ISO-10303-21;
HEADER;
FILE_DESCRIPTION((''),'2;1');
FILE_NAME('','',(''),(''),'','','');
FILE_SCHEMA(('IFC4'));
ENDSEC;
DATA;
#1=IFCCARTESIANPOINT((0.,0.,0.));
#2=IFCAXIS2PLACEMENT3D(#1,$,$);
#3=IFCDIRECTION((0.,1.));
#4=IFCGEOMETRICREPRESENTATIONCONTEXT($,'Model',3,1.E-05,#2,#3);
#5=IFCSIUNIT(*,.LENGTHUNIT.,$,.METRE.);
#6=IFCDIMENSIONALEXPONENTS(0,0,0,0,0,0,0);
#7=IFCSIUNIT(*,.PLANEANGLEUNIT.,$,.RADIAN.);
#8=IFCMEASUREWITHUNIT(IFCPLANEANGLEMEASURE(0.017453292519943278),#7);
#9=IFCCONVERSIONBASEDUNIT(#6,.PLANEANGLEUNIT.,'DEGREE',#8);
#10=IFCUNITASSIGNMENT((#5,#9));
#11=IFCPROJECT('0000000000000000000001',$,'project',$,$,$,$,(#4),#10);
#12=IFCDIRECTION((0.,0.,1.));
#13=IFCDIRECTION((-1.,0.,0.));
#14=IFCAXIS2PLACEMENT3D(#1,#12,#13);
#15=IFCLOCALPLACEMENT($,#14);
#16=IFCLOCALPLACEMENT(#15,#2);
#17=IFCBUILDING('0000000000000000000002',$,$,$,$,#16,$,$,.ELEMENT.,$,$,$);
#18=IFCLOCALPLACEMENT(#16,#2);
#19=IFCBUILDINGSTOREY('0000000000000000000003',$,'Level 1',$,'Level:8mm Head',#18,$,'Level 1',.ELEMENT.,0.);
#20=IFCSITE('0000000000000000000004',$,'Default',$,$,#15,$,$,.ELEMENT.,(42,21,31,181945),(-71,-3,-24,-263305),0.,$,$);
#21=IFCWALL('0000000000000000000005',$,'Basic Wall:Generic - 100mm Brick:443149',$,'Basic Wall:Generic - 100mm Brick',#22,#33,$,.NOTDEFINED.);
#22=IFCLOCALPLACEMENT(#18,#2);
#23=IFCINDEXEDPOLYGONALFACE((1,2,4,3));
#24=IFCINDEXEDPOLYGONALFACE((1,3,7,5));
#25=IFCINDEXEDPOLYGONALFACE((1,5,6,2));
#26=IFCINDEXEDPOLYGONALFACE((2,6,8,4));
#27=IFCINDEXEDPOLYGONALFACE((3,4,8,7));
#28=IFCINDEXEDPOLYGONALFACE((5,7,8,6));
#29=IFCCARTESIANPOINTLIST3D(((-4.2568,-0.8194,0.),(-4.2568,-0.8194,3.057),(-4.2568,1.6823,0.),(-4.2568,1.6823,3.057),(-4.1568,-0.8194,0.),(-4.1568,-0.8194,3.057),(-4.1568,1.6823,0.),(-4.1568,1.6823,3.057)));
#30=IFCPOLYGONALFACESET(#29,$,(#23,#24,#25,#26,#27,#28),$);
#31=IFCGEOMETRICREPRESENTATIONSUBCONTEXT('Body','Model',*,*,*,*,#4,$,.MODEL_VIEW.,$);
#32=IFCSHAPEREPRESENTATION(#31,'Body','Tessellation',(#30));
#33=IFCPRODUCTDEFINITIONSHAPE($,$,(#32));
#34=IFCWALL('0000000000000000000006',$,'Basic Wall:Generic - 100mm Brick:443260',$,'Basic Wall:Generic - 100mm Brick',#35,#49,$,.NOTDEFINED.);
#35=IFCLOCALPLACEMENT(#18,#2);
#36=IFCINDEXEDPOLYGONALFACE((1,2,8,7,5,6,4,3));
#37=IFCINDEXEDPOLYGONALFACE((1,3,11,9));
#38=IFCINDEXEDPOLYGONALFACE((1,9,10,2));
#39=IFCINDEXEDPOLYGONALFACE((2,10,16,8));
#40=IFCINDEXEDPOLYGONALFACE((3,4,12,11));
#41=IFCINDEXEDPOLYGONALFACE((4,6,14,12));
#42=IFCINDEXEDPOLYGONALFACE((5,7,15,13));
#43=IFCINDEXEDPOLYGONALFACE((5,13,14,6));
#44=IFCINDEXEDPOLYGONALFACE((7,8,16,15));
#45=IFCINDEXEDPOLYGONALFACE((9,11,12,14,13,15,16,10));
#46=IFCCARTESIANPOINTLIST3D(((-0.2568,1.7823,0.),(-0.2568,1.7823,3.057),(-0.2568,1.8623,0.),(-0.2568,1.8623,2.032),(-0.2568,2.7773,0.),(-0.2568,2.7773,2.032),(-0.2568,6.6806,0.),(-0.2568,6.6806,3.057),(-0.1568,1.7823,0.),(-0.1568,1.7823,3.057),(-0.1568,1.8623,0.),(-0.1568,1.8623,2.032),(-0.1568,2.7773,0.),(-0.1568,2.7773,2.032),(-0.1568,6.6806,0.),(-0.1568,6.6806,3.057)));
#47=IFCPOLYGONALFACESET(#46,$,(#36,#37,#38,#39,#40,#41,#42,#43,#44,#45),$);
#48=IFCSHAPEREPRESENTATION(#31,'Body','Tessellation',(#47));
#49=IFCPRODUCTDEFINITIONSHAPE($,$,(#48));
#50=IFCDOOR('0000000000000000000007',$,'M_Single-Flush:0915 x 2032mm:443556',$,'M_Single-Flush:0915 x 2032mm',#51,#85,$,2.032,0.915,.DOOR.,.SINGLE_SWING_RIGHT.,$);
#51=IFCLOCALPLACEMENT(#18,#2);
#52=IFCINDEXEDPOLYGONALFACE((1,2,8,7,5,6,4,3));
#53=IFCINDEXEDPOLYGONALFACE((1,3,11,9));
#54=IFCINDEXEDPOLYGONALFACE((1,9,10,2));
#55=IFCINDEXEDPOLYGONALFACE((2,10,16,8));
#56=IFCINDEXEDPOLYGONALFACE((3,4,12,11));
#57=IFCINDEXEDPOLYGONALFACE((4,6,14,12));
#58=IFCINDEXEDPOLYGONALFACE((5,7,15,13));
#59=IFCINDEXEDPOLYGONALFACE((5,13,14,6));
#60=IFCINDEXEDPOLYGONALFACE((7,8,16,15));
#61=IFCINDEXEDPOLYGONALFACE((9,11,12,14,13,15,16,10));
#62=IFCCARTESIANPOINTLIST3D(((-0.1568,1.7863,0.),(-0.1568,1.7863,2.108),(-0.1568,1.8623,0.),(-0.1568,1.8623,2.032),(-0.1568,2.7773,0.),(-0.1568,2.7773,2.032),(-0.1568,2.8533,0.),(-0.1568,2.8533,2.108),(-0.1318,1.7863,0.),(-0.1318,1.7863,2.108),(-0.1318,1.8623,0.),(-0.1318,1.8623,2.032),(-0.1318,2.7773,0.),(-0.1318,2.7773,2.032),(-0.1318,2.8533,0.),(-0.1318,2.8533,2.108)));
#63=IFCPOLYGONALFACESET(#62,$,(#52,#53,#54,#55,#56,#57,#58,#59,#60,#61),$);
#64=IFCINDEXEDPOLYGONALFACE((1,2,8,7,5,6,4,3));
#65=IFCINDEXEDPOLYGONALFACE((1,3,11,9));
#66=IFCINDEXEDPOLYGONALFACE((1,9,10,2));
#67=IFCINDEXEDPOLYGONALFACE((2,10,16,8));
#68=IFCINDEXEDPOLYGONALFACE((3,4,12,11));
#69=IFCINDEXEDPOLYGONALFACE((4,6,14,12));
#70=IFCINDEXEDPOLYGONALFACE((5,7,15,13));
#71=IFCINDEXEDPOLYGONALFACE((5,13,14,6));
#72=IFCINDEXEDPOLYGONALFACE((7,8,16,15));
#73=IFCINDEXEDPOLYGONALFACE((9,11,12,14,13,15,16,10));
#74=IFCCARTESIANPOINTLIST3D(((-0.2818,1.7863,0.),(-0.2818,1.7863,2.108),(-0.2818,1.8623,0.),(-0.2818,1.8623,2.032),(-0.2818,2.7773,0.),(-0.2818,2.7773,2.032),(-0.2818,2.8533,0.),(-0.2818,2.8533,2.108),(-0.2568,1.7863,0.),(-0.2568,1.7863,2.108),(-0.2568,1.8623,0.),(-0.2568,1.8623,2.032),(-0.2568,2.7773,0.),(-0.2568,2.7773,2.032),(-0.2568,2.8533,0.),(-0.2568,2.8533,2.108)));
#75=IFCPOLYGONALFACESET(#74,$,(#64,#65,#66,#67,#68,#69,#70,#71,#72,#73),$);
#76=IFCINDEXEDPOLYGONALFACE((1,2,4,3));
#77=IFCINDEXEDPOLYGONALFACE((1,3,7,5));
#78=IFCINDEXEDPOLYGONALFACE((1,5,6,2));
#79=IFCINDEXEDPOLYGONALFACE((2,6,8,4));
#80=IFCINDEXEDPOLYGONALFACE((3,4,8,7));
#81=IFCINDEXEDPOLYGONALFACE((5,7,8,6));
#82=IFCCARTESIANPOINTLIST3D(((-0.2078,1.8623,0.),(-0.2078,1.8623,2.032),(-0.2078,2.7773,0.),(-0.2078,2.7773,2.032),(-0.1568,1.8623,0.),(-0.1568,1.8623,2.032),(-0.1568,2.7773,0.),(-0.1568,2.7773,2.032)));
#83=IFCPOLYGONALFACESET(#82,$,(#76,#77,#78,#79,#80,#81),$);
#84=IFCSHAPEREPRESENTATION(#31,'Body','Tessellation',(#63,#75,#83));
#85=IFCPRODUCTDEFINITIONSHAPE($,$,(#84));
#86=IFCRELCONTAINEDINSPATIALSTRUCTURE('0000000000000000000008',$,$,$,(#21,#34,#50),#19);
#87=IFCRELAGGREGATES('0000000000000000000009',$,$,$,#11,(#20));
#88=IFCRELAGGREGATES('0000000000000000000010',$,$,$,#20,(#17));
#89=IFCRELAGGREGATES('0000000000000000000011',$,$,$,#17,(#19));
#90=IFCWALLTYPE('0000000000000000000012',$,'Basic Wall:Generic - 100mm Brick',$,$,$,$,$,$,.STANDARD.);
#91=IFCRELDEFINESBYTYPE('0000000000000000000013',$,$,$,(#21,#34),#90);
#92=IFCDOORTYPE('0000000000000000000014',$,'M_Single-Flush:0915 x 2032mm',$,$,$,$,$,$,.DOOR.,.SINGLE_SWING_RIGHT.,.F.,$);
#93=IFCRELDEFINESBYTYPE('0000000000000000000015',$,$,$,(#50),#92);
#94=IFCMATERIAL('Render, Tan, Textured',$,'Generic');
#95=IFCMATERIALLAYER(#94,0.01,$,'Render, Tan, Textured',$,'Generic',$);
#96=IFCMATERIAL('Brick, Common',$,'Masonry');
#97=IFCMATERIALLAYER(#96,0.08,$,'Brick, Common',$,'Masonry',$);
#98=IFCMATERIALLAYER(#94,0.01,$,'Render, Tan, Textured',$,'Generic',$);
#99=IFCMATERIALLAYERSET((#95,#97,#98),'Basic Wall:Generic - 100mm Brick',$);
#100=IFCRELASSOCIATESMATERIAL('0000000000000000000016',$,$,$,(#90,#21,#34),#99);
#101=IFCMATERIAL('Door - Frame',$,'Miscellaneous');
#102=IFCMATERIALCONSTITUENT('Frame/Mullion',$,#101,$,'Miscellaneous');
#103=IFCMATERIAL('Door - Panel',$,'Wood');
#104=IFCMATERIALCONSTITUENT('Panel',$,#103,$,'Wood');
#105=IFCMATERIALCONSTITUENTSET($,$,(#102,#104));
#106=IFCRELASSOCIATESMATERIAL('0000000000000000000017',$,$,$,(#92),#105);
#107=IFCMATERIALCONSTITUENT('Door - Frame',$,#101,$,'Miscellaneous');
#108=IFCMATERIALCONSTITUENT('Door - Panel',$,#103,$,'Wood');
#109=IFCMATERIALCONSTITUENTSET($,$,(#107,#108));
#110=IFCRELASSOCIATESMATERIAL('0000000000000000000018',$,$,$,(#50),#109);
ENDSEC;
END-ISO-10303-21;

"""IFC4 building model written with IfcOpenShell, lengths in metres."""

from ifc_helpers import new_model, entity, si_unit, converted_unit, direction, frame, frame_2d, origin, place, context, subcontext, project, spatial, polyline, rectangle, outline, extrude, source, transform, mapped, material, layer, layer_set, layer_usage, constituent, constituent_set, type_object, type_shapes, element, fill, save


model = new_model("IFC4")

# Units and contexts
model_context = context("Model", 3, precision=1e-05, world=origin(), true_north=direction((0.0, 1.0)))
body_context = subcontext(model_context, "Body", "Model", "MODEL_VIEW")
ifc_project = project(units=[si_unit("LENGTHUNIT", "METRE"), converted_unit("PLANEANGLEUNIT", "DEGREE", entity("IfcPlaneAngleMeasure", 0.017453292519943278), si_unit("PLANEANGLEUNIT", "RADIAN"), dimensions=[0, 0, 0, 0, 0, 0, 0])], contexts=[model_context])

# Site, building, storey
site_placement = place(None, frame((0.0, 0.0, 0.0), z_axis=(0.0, 0.0, 1.0), x_axis=(-1.0, 0.0, 0.0)))
site = spatial("IfcSite", under=ifc_project, at=site_placement, Name="Default", CompositionType="ELEMENT", RefLatitude=(42, 21, 31, 181945), RefLongitude=(-71, -3, -24, -263305), RefElevation=0.0)
building_placement = place(site_placement, origin())
building = spatial("IfcBuilding", under=site, at=building_placement, CompositionType="ELEMENT")
storey_placement = place(building_placement, origin())
storey = spatial("IfcBuildingStorey", under=building, at=storey_placement, Name="Level 1", ObjectType="Level:8mm Head", LongName="Level 1", CompositionType="ELEMENT", Elevation=0.0)

# Shared definitions
ifc_material_1 = material(Name="Brick, Common", Category="Masonry")

# Shared definitions
ifc_material_2 = material(Name="Render, Tan, Textured", Category="Generic")
ifc_layer_1 = layer(ifc_material_2, 0.01, Name="Render, Tan, Textured", Category="Generic")
ifc_layer_2 = layer(ifc_material_1, 0.08, Name="Brick, Common", Category="Masonry")
ifc_layer_3 = layer(ifc_material_2, 0.01, Name="Render, Tan, Textured", Category="Generic")
ifc_layer_set_1 = layer_set([ifc_layer_1, ifc_layer_2, ifc_layer_3], Name="Basic Wall:Generic - 100mm Brick")
ifc_layer_usage_1 = layer_usage(ifc_layer_set_1, "AXIS2", "NEGATIVE", 0.05)
wall_type_1 = type_object("IfcWallType", Name="Basic Wall:Generic - 100mm Brick", PredefinedType="STANDARD", material=ifc_layer_set_1)
ifc_material_3 = material(Name="Door - Frame", Category="Miscellaneous")
ifc_material_4 = material(Name="Door - Panel", Category="Wood")
ifc_constituent_1 = constituent(ifc_material_3, Name="Frame/Mullion", Category="Miscellaneous")
ifc_constituent_2 = constituent(ifc_material_4, Name="Panel", Category="Wood")
ifc_constituent_set_1 = constituent_set(constituents=[ifc_constituent_1, ifc_constituent_2])
door_type_1 = type_object("IfcDoorType", Name="M_Single-Flush:0915 x 2032mm", OperationType="SINGLE_SWING_RIGHT", ParameterTakesPrecedence=False, PredefinedType="DOOR", material=ifc_constituent_set_1)
shared_shape_1 = source(origin(), body_context, "Body", "SweptSolid", [
    extrude(outline(polyline([(-0.5335, -1.073), (0.5335, -1.073), (0.5335, 1.035), (0.4575, 1.035), (0.4575, -0.997), (-0.4575, -0.997), (-0.4575, 1.035), (-0.5335, 1.035), (-0.5335, -1.073)])), frame((0.4575, 0.1, 1.035), z_axis=(0.0, 1.0, 0.0), x_axis=(1.0, 0.0, 0.0)), (0.0, 0.0, 1.0), 0.025),
    extrude(outline(polyline([(-1.073, -0.5335), (1.035, -0.5335), (1.035, -0.4575), (-0.997, -0.4575), (-0.997, 0.4575), (1.035, 0.4575), (1.035, 0.5335), (-1.073, 0.5335), (-1.073, -0.5335)])), frame((0.4575, -0.025, 1.035), z_axis=(0.0, 1.0, 0.0), x_axis=(0.0, 0.0, -1.0)), (0.0, 0.0, 1.0), 0.025),
    extrude(rectangle(XDim=0.051, YDim=0.915, at=frame_2d((0.0, 0.0), x_axis=(1.0, 0.0))), frame((0.4575, 0.0745, 0.0), z_axis=(0.0, 0.0, 1.0), x_axis=(0.0, 1.0, 0.0)), (0.0, 0.0, 1.0), 2.032),
])
type_shapes(door_type_1, [shared_shape_1])

# Wall
wall_1_placement = place(storey_placement, frame((-4.2068, -0.8194, 0.0), z_axis=(0.0, 0.0, 1.0), x_axis=(0.0, 1.0, 0.0)))
element("IfcWall", 1, at=wall_1_placement, inside=storey, type_object=wall_type_1, material=ifc_layer_usage_1, Name="Basic Wall:Generic - 100mm Brick:443149", ObjectType="Basic Wall:Generic - 100mm Brick", PredefinedType="NOTDEFINED", context=body_context, shape_type="SweptSolid", body=[
    extrude(rectangle(XDim=2.5017, YDim=0.1, at=frame_2d((1.2508, 0.0), x_axis=(-1.0, 0.0))), origin(), (0.0, 0.0, 1.0), 3.057),
])

# Wall, opening, door
wall_2_placement = place(storey_placement, frame((-0.2068, 6.6806, 0.0), z_axis=(0.0, 0.0, 1.0), x_axis=(0.0, -1.0, 0.0)))
wall_2 = element("IfcWall", 2, at=wall_2_placement, inside=storey, type_object=wall_type_1, material=ifc_layer_usage_1, Name="Basic Wall:Generic - 100mm Brick:443260", ObjectType="Basic Wall:Generic - 100mm Brick", PredefinedType="NOTDEFINED", context=body_context, shape_type="SweptSolid", body=[
    extrude(rectangle(XDim=4.8983, YDim=0.1, at=frame_2d((2.4492, 0.0), x_axis=(-1.0, 0.0))), origin(), (0.0, 0.0, 1.0), 3.057),
])
opening_1_placement = place(wall_2_placement, frame((3.9033, -0.05, 0.0)))
opening_1 = element("IfcOpeningElement", 3, at=opening_1_placement, cuts=wall_2, PredefinedType="OPENING", context=body_context, shape_type="SweptSolid", body=[
    extrude(rectangle(XDim=0.915, YDim=2.032, at=frame_2d((1.016, 0.4575), x_axis=(0.0, 1.0))), frame((0.0, 0.0, 0.0), z_axis=(0.0, 1.0, 0.0), x_axis=(0.0, 0.0, 1.0)), (0.0, 0.0, 1.0), 0.1),
])
ifc_constituent_3 = constituent(ifc_material_3, Name="Door - Frame", Category="Miscellaneous")
ifc_constituent_4 = constituent(ifc_material_4, Name="Door - Panel", Category="Wood")
ifc_constituent_set_2 = constituent_set(constituents=[ifc_constituent_3, ifc_constituent_4])
door_1_placement = place(opening_1_placement, origin())
door_1 = element("IfcDoor", 4, at=door_1_placement, inside=storey, type_object=door_type_1, material=ifc_constituent_set_2, Name="M_Single-Flush:0915 x 2032mm:443556", ObjectType="M_Single-Flush:0915 x 2032mm", OperationType="SINGLE_SWING_RIGHT", OverallHeight=2.032, OverallWidth=0.915, PredefinedType="DOOR", context=body_context, shape_type="MappedRepresentation", body=[
    mapped(shared_shape_1, transform((0.0, 0.0, 0.0), scale=1.0)),
])
fill(opening_1, door_1)

save(model, "model.ifc")
